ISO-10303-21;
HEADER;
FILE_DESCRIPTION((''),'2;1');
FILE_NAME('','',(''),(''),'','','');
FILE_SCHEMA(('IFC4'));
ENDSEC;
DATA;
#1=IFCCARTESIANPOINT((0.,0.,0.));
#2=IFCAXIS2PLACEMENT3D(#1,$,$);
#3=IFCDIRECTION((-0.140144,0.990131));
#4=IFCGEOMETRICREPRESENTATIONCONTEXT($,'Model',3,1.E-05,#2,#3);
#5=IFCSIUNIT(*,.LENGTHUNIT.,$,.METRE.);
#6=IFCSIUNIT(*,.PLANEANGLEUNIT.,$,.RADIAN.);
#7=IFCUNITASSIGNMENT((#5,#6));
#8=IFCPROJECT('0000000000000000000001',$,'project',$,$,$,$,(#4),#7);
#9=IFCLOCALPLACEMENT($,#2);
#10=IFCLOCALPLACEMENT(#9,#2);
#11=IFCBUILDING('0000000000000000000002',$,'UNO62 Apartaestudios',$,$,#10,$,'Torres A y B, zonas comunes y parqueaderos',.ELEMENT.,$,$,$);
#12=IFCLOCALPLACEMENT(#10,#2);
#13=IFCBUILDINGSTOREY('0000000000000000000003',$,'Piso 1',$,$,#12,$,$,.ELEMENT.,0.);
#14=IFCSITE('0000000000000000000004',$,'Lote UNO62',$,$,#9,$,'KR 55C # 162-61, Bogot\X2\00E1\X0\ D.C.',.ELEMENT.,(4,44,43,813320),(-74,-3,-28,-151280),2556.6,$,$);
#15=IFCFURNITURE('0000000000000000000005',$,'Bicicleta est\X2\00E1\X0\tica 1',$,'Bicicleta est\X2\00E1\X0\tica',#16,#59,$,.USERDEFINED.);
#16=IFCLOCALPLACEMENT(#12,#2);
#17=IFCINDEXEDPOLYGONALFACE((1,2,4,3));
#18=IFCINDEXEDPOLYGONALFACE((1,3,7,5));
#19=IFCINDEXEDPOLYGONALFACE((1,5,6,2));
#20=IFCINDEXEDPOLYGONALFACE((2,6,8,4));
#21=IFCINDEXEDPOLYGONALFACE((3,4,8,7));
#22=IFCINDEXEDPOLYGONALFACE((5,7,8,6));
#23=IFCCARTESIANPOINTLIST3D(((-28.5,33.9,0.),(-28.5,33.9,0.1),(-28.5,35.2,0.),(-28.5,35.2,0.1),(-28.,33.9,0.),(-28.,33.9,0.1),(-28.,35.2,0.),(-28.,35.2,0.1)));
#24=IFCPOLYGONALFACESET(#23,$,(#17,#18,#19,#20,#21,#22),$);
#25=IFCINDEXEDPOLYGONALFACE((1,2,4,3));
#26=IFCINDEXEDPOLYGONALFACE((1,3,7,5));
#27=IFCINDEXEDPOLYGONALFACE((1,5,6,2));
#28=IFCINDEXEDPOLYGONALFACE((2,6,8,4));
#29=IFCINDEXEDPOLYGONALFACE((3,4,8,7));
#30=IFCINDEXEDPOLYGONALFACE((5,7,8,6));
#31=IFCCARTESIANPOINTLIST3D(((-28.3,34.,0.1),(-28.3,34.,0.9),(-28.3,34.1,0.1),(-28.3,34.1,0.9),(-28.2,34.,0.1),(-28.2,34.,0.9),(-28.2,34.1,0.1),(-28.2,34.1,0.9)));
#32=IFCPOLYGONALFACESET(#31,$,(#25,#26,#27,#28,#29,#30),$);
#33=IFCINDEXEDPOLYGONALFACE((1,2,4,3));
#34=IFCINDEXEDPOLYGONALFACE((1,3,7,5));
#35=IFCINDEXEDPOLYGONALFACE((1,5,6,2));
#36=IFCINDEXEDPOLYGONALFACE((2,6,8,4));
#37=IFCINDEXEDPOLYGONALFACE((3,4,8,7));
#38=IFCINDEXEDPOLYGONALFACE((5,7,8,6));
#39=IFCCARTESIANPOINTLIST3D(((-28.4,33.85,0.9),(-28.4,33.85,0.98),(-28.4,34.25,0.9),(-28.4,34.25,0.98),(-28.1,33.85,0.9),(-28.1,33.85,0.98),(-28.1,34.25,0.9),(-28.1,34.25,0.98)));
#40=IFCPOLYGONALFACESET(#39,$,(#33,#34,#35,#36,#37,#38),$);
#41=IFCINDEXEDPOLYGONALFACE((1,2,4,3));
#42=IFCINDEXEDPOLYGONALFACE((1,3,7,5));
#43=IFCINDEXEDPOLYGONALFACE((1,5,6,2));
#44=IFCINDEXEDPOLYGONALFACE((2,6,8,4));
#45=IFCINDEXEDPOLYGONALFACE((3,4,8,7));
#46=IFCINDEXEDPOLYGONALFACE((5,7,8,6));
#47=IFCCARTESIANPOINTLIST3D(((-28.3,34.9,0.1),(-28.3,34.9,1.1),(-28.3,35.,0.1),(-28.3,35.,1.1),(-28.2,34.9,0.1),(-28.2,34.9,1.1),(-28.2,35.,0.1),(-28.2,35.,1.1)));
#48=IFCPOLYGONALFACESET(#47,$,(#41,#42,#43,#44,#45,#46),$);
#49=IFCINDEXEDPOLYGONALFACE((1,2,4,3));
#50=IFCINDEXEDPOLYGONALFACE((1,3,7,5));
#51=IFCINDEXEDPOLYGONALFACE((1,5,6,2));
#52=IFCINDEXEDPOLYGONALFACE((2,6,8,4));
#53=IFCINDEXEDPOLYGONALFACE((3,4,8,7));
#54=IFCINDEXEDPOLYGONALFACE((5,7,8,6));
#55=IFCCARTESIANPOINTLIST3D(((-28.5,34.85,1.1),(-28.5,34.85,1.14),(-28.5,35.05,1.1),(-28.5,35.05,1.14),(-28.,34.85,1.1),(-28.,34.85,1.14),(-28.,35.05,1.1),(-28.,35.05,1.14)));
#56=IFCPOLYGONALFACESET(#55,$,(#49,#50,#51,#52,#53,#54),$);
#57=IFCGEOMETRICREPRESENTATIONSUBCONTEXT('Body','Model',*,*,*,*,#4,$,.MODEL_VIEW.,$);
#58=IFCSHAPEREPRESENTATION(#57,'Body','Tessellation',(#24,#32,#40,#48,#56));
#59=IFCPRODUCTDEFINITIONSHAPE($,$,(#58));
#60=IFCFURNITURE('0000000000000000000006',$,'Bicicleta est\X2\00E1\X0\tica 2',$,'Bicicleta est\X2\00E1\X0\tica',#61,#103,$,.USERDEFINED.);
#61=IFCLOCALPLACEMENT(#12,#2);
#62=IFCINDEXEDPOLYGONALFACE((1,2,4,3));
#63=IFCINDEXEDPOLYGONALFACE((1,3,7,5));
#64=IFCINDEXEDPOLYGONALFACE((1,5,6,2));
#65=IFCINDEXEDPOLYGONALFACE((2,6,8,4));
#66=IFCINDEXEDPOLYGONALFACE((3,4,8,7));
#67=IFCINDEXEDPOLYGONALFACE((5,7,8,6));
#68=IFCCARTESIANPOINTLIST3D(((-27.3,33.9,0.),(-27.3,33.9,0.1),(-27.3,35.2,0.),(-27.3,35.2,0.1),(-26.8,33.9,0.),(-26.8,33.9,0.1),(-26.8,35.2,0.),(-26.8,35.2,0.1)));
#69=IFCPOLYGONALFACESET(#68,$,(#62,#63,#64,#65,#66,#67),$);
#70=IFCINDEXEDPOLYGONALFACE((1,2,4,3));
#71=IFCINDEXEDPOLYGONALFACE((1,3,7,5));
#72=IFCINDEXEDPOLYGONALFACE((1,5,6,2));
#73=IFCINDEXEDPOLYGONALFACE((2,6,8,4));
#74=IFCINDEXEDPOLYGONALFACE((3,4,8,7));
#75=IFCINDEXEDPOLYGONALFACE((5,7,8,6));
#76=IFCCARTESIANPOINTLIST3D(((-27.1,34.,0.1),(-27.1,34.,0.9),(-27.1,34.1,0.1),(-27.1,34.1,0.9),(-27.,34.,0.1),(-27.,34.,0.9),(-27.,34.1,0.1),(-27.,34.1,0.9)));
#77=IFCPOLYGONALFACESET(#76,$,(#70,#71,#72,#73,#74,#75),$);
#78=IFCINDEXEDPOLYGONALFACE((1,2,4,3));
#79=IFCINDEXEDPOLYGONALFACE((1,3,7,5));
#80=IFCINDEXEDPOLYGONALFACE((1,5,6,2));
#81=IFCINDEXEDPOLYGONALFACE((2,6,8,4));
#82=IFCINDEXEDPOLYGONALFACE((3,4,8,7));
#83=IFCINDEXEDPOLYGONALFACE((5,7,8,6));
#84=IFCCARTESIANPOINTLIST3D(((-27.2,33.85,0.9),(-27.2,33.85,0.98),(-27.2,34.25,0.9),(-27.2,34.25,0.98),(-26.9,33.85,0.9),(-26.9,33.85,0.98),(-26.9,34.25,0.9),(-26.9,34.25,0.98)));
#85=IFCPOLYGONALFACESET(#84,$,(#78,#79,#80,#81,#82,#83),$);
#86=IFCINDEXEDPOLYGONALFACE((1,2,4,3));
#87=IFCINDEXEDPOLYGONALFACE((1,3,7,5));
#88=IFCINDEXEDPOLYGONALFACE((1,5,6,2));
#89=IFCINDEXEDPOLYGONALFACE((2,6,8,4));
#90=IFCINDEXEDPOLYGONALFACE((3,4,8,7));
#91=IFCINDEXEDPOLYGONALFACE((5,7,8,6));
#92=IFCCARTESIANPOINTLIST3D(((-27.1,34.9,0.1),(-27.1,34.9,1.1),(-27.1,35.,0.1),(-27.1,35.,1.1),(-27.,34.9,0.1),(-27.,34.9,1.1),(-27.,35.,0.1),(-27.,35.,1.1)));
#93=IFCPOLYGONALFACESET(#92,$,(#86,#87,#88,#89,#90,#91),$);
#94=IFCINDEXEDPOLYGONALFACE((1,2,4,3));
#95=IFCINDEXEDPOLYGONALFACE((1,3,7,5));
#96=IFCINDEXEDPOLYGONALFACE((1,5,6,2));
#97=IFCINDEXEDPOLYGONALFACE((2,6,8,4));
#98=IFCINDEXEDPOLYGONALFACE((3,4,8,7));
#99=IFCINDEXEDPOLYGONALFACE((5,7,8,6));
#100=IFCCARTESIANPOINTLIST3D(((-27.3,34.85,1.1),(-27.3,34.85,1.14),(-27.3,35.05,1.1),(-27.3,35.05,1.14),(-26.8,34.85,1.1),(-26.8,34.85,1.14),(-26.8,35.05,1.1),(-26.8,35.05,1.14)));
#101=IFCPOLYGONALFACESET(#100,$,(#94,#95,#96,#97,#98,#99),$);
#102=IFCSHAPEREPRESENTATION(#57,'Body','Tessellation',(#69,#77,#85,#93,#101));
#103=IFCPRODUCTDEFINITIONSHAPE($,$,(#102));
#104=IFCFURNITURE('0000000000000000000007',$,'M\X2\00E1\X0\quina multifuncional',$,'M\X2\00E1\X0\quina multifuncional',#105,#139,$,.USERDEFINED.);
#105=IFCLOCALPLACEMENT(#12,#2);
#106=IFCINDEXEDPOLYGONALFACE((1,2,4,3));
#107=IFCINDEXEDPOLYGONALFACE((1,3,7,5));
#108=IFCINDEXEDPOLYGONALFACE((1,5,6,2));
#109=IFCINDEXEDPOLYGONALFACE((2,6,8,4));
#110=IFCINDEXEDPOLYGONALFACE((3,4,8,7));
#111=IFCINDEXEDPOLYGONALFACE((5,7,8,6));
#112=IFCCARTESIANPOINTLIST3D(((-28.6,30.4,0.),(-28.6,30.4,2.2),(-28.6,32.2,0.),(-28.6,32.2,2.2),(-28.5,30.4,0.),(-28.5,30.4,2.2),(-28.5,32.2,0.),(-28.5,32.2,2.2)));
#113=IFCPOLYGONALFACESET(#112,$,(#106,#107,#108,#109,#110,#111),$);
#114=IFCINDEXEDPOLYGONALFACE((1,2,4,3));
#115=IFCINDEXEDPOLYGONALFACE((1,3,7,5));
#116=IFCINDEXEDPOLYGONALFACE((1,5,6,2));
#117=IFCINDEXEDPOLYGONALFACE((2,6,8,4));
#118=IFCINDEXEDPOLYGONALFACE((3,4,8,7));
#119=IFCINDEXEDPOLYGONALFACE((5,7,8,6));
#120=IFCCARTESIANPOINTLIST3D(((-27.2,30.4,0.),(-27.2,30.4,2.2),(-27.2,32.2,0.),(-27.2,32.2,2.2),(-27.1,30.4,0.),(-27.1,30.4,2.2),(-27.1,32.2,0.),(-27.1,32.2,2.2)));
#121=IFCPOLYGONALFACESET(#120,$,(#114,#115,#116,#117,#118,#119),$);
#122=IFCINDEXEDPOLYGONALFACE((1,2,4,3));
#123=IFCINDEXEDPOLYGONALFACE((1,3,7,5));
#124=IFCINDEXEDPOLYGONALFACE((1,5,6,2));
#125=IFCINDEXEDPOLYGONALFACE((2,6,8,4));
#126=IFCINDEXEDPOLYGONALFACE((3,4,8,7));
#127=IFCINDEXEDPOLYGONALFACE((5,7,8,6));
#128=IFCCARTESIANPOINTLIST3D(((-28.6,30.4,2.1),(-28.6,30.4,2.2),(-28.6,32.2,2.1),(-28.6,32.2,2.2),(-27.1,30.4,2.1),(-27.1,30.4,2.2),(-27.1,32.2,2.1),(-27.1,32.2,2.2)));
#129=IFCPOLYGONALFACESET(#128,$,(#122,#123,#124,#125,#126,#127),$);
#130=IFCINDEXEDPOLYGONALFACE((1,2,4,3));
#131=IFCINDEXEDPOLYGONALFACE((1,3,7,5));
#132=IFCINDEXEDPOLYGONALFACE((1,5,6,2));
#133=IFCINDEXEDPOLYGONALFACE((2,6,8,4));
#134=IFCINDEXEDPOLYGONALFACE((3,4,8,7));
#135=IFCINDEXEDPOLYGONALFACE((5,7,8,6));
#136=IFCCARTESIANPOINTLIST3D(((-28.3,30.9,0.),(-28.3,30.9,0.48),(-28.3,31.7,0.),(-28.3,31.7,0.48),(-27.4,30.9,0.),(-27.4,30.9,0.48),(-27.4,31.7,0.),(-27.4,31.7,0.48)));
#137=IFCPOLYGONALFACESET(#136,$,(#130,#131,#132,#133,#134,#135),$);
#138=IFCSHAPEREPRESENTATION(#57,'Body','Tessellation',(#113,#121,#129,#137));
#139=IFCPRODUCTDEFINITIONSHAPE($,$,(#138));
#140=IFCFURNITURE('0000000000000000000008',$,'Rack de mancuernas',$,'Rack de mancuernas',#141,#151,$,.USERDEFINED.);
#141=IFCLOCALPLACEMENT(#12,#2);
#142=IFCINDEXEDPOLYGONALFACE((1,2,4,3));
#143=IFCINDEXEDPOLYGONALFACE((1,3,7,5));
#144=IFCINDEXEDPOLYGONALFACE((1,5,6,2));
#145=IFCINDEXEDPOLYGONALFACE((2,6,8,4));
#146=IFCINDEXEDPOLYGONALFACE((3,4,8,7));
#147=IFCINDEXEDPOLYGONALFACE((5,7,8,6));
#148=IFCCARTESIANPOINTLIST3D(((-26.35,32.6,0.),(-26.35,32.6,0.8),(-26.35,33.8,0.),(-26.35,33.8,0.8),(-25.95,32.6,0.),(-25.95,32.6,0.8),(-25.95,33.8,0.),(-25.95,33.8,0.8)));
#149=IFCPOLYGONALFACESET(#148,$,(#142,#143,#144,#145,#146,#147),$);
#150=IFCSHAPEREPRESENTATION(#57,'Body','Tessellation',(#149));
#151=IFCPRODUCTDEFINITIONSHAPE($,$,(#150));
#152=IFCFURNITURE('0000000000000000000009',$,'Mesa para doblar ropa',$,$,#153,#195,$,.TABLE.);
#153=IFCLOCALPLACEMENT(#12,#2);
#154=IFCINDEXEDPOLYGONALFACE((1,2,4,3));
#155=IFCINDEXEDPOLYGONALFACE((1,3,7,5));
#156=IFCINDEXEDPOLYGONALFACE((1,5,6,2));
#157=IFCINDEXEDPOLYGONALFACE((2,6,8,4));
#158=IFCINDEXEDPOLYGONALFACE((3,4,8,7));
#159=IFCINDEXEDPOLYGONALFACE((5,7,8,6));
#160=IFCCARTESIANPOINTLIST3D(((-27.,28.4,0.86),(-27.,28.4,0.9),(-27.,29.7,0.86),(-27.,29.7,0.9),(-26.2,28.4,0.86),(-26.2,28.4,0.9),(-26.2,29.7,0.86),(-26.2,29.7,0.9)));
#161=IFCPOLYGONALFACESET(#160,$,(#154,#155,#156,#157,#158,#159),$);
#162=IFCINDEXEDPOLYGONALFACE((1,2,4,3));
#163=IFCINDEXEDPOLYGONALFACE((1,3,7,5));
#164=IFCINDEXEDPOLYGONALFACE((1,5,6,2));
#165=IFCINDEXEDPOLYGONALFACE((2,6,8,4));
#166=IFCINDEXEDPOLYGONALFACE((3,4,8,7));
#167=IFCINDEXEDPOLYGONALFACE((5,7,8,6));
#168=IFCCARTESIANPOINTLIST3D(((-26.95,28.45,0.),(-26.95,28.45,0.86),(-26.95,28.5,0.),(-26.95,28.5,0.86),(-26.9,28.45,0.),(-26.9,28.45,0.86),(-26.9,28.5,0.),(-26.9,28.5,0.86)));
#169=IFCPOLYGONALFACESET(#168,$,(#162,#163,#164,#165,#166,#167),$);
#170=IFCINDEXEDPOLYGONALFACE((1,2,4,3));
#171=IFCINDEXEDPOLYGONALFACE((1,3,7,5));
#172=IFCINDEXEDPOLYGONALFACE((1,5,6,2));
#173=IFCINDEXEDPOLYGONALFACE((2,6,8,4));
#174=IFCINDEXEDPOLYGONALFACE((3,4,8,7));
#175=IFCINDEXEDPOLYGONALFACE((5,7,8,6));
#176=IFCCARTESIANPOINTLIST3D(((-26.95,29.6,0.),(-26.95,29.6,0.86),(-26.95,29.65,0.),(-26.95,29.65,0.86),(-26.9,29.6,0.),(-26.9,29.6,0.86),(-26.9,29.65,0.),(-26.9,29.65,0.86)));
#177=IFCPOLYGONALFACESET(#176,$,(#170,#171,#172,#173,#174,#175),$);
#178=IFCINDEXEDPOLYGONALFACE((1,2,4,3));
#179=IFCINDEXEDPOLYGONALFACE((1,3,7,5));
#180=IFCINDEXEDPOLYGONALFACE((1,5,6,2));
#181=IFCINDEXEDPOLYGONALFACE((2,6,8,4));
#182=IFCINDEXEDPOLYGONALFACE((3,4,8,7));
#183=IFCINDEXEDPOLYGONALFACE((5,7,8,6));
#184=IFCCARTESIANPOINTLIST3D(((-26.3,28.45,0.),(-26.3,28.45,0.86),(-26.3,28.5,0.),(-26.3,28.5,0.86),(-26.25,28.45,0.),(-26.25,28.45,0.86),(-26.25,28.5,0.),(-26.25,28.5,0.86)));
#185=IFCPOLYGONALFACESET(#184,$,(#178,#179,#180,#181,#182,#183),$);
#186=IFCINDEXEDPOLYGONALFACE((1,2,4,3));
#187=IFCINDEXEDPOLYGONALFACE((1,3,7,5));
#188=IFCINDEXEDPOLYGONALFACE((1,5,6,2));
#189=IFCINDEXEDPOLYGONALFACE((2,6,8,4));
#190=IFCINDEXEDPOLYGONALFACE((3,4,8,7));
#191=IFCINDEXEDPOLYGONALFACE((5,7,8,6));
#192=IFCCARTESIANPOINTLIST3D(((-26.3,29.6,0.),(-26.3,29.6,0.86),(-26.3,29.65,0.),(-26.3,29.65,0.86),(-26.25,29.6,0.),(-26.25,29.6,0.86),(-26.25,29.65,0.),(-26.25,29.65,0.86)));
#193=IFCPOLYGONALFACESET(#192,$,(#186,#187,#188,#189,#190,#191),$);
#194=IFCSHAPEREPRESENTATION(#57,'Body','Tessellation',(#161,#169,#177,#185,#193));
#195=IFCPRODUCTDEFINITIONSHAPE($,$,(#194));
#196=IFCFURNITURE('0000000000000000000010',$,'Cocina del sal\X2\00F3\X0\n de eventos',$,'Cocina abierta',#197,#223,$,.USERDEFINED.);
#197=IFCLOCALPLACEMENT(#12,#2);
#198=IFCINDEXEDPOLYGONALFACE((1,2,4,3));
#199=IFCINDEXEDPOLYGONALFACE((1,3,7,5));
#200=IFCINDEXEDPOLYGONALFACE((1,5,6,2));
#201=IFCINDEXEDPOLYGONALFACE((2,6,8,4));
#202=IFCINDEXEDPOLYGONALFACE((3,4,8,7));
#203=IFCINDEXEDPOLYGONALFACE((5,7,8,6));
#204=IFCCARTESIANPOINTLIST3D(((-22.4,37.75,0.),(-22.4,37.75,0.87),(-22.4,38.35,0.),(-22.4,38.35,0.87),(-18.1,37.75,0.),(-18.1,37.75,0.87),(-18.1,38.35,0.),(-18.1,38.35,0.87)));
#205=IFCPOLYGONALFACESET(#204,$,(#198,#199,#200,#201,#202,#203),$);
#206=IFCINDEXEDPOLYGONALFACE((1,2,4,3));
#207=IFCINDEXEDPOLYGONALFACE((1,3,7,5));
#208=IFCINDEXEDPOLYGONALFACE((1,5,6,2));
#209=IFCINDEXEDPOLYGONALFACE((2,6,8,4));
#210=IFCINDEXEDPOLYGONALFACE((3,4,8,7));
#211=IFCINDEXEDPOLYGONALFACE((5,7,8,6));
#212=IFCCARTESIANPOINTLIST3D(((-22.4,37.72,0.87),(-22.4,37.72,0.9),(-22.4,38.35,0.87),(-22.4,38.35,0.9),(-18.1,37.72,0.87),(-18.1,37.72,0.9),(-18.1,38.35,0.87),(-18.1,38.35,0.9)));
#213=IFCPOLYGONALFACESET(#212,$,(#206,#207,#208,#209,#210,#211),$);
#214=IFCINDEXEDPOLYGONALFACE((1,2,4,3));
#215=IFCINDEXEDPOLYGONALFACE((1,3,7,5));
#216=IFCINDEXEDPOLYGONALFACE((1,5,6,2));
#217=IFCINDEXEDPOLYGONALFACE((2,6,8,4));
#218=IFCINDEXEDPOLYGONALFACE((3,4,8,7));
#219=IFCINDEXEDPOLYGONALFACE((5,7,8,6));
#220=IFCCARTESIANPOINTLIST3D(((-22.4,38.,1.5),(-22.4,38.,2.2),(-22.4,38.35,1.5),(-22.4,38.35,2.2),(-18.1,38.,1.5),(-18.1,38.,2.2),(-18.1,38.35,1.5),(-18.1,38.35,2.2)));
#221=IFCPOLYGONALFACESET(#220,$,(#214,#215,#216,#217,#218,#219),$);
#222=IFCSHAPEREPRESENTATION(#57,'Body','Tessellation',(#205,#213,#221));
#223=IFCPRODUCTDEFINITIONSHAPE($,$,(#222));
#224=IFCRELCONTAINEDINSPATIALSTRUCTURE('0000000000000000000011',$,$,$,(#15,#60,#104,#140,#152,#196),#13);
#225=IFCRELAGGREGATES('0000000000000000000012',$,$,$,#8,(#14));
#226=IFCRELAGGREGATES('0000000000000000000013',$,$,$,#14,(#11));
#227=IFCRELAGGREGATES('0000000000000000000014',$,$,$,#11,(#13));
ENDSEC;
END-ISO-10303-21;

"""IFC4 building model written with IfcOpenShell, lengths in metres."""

from ifc_helpers import new_model, si_unit, direction, frame, frame_2d, origin, place, context, subcontext, project, spatial, rectangle, extrude, element, save


model = new_model("IFC4")

# Units and contexts
model_context = context("Model", 3, precision=1e-05, world=origin(), true_north=direction((-0.140144, 0.990131)))
body_context = subcontext(model_context, "Body", "Model", "MODEL_VIEW")
ifc_project = project(units=[si_unit("LENGTHUNIT", "METRE"), si_unit("PLANEANGLEUNIT", "RADIAN")], contexts=[model_context])

# Site, building, storey
site_placement = place(None, origin())
site = spatial("IfcSite", under=ifc_project, at=site_placement, Name="Lote UNO62", LongName="KR 55C # 162-61, Bogotá D.C.", CompositionType="ELEMENT", RefLatitude=(4, 44, 43, 813320), RefLongitude=(-74, -3, -28, -151280), RefElevation=2556.6)
building_placement = place(site_placement, origin())
building = spatial("IfcBuilding", under=site, at=building_placement, Name="UNO62 Apartaestudios", LongName="Torres A y B, zonas comunes y parqueaderos", CompositionType="ELEMENT")
storey_placement = place(building_placement, origin())
storey = spatial("IfcBuildingStorey", under=building, at=storey_placement, Name="Piso 1", CompositionType="ELEMENT", Elevation=0.0)

# Furniture
furniture_1_placement = place(storey_placement, origin())
element("IfcFurniture", 1, at=furniture_1_placement, inside=storey, Name="Bicicleta estática 1", ObjectType="Bicicleta estática", PredefinedType="USERDEFINED", context=body_context, shape_type="SweptSolid", body=[
    extrude(rectangle(XDim=0.5, YDim=1.3, at=frame_2d((-28.25, 34.55))), origin(), (0.0, 0.0, 1.0), 0.1),
    extrude(rectangle(XDim=0.1, YDim=0.1, at=frame_2d((-28.25, 34.05))), frame((0.0, 0.0, 0.1)), (0.0, 0.0, 1.0), 0.8),
    extrude(rectangle(XDim=0.3, YDim=0.4, at=frame_2d((-28.25, 34.05))), frame((0.0, 0.0, 0.9)), (0.0, 0.0, 1.0), 0.08),
    extrude(rectangle(XDim=0.1, YDim=0.1, at=frame_2d((-28.25, 34.95))), frame((0.0, 0.0, 0.1)), (0.0, 0.0, 1.0), 1.0),
    extrude(rectangle(XDim=0.5, YDim=0.2, at=frame_2d((-28.25, 34.95))), frame((0.0, 0.0, 1.1)), (0.0, 0.0, 1.0), 0.04),
])
furniture_2_placement = place(storey_placement, origin())
element("IfcFurniture", 2, at=furniture_2_placement, inside=storey, Name="Bicicleta estática 2", ObjectType="Bicicleta estática", PredefinedType="USERDEFINED", context=body_context, shape_type="SweptSolid", body=[
    extrude(rectangle(XDim=0.5, YDim=1.3, at=frame_2d((-27.05, 34.55))), origin(), (0.0, 0.0, 1.0), 0.1),
    extrude(rectangle(XDim=0.1, YDim=0.1, at=frame_2d((-27.05, 34.05))), frame((0.0, 0.0, 0.1)), (0.0, 0.0, 1.0), 0.8),
    extrude(rectangle(XDim=0.3, YDim=0.4, at=frame_2d((-27.05, 34.05))), frame((0.0, 0.0, 0.9)), (0.0, 0.0, 1.0), 0.08),
    extrude(rectangle(XDim=0.1, YDim=0.1, at=frame_2d((-27.05, 34.95))), frame((0.0, 0.0, 0.1)), (0.0, 0.0, 1.0), 1.0),
    extrude(rectangle(XDim=0.5, YDim=0.2, at=frame_2d((-27.05, 34.95))), frame((0.0, 0.0, 1.1)), (0.0, 0.0, 1.0), 0.04),
])
furniture_3_placement = place(storey_placement, origin())
element("IfcFurniture", 3, at=furniture_3_placement, inside=storey, Name="Máquina multifuncional", ObjectType="Máquina multifuncional", PredefinedType="USERDEFINED", context=body_context, shape_type="SweptSolid", body=[
    extrude(rectangle(XDim=0.1, YDim=1.8, at=frame_2d((-28.55, 31.3))), origin(), (0.0, 0.0, 1.0), 2.2),
    extrude(rectangle(XDim=0.1, YDim=1.8, at=frame_2d((-27.15, 31.3))), origin(), (0.0, 0.0, 1.0), 2.2),
    extrude(rectangle(XDim=1.5, YDim=1.8, at=frame_2d((-27.85, 31.3))), frame((0.0, 0.0, 2.1)), (0.0, 0.0, 1.0), 0.1),
    extrude(rectangle(XDim=0.9, YDim=0.8, at=frame_2d((-27.85, 31.3))), origin(), (0.0, 0.0, 1.0), 0.48),
])
furniture_4_placement = place(storey_placement, origin())
element("IfcFurniture", 4, at=furniture_4_placement, inside=storey, Name="Rack de mancuernas", ObjectType="Rack de mancuernas", PredefinedType="USERDEFINED", context=body_context, shape_type="SweptSolid", body=[
    extrude(rectangle(XDim=0.4, YDim=1.2, at=frame_2d((-26.15, 33.2))), origin(), (0.0, 0.0, 1.0), 0.8),
])
furniture_5_placement = place(storey_placement, origin())
element("IfcFurniture", 5, at=furniture_5_placement, inside=storey, Name="Mesa para doblar ropa", PredefinedType="TABLE", context=body_context, shape_type="SweptSolid", body=[
    extrude(rectangle(XDim=0.8, YDim=1.3, at=frame_2d((-26.6, 29.05))), frame((0.0, 0.0, 0.86)), (0.0, 0.0, 1.0), 0.04),
    extrude(rectangle(XDim=0.05, YDim=0.05, at=frame_2d((-26.925, 28.475))), origin(), (0.0, 0.0, 1.0), 0.86),
    extrude(rectangle(XDim=0.05, YDim=0.05, at=frame_2d((-26.925, 29.625))), origin(), (0.0, 0.0, 1.0), 0.86),
    extrude(rectangle(XDim=0.05, YDim=0.05, at=frame_2d((-26.275, 28.475))), origin(), (0.0, 0.0, 1.0), 0.86),
    extrude(rectangle(XDim=0.05, YDim=0.05, at=frame_2d((-26.275, 29.625))), origin(), (0.0, 0.0, 1.0), 0.86),
])
furniture_6_placement = place(storey_placement, origin())
element("IfcFurniture", 6, at=furniture_6_placement, inside=storey, Name="Cocina del salón de eventos", ObjectType="Cocina abierta", PredefinedType="USERDEFINED", context=body_context, shape_type="SweptSolid", body=[
    extrude(rectangle(XDim=4.3, YDim=0.6, at=frame_2d((-20.25, 38.05))), origin(), (0.0, 0.0, 1.0), 0.87),
    extrude(rectangle(XDim=4.3, YDim=0.63, at=frame_2d((-20.25, 38.035))), frame((0.0, 0.0, 0.87)), (0.0, 0.0, 1.0), 0.03),
    extrude(rectangle(XDim=4.3, YDim=0.35, at=frame_2d((-20.25, 38.175))), frame((0.0, 0.0, 1.5)), (0.0, 0.0, 1.0), 0.7),
])

save(model, "model.ifc")
